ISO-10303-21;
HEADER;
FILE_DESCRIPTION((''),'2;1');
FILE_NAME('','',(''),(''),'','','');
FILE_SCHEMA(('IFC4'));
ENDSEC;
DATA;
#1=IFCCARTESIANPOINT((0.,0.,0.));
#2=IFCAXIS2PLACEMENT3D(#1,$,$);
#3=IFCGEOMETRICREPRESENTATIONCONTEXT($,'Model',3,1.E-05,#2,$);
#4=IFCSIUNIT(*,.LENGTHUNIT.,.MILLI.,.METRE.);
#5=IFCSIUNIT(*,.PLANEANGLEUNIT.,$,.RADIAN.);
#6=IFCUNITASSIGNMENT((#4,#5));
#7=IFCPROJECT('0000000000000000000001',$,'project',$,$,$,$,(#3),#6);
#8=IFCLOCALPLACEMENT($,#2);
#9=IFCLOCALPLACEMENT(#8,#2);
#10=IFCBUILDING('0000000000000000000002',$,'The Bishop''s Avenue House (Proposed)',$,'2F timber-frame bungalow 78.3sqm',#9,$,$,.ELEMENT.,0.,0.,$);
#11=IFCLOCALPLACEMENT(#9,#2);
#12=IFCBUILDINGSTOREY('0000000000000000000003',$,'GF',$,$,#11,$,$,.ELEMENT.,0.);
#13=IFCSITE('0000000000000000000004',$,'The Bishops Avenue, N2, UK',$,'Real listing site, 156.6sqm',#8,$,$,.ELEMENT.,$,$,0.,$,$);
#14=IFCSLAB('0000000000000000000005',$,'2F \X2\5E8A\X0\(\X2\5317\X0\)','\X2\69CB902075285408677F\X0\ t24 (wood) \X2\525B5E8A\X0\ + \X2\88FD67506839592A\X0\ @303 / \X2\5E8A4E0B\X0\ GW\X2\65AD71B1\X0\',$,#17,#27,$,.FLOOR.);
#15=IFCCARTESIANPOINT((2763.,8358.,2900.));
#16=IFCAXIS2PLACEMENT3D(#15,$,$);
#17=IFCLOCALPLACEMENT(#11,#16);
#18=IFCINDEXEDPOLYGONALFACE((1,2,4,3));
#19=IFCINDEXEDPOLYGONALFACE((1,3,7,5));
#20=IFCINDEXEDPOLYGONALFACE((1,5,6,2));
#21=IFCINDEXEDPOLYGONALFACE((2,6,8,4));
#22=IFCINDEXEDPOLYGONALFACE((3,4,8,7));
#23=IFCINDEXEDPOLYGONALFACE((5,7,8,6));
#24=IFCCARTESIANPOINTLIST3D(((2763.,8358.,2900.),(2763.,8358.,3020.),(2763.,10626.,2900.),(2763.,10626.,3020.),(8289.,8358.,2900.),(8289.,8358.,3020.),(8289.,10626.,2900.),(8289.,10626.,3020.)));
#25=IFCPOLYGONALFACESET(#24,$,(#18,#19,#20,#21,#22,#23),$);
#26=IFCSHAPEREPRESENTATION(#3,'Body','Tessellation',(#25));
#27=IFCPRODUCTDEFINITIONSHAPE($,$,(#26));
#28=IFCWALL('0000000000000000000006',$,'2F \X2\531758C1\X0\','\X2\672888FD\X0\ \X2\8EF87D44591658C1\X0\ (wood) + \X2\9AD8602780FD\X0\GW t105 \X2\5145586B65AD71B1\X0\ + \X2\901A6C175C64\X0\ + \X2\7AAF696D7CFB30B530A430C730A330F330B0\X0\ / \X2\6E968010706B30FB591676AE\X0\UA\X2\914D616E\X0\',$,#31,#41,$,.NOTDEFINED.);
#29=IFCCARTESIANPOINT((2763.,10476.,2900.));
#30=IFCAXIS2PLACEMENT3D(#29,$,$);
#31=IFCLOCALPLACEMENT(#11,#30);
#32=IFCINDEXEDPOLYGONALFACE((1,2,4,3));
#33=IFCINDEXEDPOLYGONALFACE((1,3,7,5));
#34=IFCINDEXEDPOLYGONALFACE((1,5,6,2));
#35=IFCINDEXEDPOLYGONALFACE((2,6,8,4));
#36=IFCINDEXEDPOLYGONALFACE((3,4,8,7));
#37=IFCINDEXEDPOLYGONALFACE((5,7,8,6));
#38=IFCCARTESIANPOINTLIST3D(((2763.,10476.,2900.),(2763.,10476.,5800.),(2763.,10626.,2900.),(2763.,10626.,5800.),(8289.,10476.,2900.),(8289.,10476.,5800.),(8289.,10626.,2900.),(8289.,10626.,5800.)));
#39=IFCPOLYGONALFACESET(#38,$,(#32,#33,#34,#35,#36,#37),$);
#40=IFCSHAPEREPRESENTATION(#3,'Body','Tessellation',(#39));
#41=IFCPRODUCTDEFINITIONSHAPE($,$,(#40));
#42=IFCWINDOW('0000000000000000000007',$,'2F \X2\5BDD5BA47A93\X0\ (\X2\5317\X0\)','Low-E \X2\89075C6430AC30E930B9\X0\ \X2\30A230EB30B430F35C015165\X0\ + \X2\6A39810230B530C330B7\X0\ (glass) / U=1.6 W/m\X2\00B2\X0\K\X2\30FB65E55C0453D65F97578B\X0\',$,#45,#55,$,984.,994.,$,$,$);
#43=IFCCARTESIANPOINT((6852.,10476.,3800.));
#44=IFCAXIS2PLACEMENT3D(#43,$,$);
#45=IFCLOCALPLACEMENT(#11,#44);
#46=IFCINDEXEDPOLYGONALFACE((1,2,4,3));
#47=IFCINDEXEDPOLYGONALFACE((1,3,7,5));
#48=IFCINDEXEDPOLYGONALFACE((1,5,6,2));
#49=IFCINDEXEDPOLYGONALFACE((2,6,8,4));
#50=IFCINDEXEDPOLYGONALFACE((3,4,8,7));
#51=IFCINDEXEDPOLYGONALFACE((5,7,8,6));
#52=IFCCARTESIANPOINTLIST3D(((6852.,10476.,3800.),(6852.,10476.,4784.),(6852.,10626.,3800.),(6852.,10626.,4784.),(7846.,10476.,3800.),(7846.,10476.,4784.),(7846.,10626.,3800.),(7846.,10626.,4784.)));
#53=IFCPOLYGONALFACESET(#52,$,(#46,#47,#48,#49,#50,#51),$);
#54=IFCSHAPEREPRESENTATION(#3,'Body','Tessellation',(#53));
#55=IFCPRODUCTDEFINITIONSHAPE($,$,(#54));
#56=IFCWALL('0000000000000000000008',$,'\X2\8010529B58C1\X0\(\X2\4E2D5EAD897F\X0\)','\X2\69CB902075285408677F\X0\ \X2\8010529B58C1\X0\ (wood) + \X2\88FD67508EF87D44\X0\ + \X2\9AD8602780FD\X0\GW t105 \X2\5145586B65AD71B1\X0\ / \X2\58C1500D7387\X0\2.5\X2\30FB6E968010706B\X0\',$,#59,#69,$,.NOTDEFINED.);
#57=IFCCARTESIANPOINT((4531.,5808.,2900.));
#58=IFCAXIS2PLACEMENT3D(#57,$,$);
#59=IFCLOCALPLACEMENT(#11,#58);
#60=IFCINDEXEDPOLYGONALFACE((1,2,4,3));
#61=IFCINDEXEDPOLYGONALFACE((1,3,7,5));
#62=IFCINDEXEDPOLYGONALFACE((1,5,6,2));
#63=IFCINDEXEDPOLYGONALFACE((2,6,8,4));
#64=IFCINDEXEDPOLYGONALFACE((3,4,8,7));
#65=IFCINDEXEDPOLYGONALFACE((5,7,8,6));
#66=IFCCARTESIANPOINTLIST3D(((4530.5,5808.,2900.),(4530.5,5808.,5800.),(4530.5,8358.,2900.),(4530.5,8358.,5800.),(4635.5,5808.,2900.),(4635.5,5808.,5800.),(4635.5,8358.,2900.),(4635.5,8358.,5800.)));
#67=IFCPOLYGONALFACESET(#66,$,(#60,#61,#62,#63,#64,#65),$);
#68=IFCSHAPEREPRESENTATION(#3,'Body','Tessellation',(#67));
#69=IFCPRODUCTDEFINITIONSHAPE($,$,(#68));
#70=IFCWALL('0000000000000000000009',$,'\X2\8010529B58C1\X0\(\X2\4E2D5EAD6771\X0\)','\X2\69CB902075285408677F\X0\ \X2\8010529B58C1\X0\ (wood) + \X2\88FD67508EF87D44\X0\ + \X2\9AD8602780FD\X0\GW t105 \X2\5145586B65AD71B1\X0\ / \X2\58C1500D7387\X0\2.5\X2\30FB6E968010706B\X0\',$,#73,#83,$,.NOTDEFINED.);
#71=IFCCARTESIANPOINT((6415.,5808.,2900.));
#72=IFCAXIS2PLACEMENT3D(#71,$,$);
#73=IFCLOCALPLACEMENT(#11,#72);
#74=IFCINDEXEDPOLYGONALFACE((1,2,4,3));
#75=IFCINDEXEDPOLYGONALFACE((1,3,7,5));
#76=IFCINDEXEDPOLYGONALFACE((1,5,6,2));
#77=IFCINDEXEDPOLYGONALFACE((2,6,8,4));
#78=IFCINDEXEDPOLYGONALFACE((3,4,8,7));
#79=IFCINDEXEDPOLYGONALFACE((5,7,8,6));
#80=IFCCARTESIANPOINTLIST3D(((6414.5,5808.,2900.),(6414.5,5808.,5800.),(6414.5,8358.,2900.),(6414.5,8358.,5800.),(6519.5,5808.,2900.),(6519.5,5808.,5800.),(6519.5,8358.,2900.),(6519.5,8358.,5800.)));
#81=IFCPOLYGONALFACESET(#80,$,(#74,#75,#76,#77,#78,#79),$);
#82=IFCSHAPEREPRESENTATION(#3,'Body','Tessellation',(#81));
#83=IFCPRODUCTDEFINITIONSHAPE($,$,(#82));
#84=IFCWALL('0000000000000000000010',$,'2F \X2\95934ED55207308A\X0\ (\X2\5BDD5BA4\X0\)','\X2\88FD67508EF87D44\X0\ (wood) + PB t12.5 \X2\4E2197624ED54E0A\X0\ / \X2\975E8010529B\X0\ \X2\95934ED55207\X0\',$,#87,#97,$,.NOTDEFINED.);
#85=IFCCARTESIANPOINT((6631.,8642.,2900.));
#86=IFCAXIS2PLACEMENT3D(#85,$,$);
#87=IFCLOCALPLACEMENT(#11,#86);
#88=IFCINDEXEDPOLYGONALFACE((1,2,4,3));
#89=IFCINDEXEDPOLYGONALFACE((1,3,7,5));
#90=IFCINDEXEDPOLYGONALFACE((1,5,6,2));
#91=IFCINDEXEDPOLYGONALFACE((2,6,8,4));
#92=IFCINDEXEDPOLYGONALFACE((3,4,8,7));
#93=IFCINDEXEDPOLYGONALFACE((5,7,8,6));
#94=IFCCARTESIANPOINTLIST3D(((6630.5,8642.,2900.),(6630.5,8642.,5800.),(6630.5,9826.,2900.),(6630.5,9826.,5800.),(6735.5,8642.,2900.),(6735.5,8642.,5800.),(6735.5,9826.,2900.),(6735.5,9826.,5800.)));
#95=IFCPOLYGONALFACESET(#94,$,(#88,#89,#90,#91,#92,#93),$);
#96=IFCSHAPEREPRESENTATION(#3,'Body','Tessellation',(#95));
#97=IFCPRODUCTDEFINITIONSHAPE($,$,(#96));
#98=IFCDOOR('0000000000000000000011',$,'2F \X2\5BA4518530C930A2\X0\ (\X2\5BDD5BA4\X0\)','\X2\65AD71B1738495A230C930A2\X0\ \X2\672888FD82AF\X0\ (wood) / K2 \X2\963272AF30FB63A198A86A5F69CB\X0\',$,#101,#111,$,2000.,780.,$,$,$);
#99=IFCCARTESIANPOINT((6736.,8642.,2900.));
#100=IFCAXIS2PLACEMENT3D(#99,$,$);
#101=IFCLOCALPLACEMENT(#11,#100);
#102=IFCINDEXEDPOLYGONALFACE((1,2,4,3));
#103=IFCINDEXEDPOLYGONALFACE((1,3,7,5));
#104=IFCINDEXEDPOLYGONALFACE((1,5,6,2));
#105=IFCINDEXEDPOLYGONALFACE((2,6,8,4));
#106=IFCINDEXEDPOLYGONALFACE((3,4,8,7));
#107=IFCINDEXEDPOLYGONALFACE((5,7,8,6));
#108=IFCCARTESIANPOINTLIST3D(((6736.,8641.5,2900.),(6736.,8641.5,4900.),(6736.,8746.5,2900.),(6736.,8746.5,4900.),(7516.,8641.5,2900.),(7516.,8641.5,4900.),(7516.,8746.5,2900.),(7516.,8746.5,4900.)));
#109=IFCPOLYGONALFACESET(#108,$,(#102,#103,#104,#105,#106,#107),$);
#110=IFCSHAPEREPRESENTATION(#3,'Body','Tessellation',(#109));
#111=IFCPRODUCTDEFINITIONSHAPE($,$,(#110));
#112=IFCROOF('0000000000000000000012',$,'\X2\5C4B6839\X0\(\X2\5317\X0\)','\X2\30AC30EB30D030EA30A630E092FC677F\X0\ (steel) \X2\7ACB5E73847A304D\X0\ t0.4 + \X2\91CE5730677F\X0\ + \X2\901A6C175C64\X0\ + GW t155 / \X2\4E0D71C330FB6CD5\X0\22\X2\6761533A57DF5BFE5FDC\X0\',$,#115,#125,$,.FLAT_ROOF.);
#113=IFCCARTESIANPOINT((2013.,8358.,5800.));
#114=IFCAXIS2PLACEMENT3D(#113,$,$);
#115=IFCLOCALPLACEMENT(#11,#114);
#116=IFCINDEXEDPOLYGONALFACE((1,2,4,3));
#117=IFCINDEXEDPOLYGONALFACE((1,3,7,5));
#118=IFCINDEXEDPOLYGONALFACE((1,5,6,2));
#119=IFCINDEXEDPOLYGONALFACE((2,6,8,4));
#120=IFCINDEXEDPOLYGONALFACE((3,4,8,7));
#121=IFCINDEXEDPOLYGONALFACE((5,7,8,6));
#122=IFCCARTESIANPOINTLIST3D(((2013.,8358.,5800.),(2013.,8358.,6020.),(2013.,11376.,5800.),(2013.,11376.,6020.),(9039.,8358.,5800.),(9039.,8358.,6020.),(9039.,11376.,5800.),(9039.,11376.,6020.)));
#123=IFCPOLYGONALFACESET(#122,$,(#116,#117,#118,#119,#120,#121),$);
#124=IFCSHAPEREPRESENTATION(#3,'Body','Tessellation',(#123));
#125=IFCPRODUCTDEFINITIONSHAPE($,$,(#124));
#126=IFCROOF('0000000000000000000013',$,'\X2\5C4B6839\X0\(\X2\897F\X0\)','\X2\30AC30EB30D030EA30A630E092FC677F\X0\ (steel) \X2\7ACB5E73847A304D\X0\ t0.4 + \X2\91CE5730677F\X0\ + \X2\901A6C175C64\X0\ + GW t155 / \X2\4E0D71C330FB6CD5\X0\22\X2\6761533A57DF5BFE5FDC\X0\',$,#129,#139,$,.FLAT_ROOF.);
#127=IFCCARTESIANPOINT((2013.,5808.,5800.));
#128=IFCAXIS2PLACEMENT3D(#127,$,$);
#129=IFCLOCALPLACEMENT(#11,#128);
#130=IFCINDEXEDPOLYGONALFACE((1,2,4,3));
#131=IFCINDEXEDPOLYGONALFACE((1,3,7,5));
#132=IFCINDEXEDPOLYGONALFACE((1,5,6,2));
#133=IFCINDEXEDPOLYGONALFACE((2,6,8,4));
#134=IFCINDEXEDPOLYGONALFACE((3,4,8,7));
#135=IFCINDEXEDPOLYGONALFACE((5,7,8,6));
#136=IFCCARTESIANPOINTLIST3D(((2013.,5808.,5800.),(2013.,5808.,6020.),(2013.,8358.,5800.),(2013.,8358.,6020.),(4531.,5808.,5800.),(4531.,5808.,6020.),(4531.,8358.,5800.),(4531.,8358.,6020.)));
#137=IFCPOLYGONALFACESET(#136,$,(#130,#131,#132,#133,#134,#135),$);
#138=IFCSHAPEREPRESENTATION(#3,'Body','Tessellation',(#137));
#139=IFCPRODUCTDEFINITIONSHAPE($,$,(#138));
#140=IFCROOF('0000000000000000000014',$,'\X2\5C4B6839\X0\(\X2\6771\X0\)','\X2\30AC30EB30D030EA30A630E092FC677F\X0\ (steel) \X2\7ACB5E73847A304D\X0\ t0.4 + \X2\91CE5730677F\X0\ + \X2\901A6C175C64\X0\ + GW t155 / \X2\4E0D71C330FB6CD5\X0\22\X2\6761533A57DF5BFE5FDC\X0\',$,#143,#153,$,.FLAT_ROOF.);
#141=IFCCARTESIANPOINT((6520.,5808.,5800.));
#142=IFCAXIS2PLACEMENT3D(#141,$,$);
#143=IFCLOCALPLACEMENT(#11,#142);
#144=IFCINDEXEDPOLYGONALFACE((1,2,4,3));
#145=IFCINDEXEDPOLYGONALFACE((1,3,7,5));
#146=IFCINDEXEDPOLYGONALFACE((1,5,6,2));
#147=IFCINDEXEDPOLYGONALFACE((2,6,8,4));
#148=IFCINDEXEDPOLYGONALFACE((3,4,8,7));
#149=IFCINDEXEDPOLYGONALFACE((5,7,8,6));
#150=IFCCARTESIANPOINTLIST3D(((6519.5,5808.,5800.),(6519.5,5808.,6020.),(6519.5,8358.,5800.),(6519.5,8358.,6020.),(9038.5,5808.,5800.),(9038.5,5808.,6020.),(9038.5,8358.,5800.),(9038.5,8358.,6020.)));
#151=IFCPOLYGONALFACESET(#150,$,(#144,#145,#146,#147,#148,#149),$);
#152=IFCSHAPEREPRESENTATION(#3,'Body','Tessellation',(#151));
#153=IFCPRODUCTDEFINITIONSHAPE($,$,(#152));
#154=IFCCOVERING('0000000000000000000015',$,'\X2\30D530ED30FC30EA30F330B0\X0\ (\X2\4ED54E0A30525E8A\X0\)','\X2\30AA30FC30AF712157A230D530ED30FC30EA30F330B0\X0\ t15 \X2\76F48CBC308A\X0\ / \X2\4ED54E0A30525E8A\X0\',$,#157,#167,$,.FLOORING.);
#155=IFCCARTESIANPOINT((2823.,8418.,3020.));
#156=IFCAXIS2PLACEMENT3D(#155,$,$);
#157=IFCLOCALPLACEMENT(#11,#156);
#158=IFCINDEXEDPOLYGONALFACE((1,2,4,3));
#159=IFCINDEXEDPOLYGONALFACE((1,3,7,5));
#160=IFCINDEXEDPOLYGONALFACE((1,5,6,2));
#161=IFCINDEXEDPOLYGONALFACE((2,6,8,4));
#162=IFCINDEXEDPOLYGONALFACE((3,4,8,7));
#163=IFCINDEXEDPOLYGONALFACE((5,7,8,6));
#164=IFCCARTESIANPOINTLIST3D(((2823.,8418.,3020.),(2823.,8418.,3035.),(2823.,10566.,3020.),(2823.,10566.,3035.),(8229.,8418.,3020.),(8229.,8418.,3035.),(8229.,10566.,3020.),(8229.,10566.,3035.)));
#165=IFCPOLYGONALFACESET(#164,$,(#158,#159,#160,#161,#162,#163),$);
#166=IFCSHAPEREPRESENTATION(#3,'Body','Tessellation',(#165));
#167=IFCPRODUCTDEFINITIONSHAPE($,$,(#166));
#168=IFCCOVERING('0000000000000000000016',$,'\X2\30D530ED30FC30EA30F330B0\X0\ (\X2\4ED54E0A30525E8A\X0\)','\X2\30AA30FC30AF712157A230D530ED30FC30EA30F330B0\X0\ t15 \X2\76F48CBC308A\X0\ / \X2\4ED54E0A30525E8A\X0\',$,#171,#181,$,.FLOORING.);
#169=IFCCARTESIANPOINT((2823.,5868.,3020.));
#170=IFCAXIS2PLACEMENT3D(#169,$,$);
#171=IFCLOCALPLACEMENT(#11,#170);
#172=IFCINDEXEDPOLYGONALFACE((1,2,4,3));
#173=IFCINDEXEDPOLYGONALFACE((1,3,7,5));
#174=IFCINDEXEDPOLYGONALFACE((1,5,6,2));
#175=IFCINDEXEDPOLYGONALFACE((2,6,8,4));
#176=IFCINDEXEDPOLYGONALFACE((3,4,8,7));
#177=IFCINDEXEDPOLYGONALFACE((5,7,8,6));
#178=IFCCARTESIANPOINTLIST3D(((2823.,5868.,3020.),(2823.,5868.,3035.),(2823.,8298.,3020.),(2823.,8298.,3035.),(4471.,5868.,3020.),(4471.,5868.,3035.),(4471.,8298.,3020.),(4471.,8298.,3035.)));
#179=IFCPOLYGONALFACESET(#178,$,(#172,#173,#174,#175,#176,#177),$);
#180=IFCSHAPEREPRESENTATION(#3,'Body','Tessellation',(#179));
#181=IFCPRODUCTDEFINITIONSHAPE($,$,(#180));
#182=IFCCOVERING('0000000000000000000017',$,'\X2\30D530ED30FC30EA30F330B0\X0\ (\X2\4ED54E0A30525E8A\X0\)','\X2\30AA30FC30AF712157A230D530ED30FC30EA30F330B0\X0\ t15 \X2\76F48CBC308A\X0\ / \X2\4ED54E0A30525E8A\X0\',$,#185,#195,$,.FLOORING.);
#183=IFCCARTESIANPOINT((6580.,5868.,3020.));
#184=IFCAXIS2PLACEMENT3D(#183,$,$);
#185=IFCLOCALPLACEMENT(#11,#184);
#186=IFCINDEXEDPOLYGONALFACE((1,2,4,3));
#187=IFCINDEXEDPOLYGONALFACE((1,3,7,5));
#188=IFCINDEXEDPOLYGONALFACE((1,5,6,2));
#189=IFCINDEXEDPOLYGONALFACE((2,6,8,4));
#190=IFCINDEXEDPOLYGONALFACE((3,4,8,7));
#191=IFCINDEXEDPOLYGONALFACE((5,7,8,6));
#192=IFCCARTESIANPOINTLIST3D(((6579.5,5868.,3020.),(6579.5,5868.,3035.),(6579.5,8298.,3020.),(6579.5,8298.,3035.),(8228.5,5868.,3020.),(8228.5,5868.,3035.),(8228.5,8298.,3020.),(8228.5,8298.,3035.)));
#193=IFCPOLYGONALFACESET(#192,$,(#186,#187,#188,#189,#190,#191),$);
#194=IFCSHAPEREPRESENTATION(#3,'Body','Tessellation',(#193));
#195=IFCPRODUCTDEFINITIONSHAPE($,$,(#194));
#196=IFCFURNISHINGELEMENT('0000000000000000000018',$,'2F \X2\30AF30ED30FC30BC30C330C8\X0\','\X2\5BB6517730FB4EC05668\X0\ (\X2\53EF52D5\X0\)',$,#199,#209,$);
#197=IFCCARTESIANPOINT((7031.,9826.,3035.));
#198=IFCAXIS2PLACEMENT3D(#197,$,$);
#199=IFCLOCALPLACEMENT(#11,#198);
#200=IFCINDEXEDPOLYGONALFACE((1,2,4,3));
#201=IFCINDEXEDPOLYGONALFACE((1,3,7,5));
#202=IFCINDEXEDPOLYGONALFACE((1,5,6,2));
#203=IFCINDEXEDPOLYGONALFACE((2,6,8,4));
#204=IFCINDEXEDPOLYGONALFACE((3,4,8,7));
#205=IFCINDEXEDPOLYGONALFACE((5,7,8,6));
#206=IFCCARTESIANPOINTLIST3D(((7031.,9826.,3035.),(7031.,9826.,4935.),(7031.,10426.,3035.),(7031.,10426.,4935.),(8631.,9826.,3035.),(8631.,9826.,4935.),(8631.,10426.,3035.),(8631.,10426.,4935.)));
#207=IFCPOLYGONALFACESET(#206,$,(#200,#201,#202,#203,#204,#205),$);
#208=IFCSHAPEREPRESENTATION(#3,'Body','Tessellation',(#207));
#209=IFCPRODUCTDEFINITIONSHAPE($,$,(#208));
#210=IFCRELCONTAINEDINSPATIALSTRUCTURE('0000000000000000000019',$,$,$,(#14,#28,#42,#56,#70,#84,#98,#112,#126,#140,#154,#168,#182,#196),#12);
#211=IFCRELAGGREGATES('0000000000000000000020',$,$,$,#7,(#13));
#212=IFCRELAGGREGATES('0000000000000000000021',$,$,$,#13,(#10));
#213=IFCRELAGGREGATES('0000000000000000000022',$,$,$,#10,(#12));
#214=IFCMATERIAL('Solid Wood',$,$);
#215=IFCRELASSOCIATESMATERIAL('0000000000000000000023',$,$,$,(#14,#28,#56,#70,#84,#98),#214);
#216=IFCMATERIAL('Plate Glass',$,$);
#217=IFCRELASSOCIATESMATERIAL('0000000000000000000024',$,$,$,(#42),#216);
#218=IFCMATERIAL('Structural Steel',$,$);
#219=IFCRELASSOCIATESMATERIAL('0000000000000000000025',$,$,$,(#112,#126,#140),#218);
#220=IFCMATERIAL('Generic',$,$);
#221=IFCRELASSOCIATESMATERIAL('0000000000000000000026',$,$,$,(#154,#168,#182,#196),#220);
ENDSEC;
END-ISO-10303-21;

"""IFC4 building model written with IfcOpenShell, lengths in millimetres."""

from ifc_helpers import new_model, si_unit, frame, frame_2d, origin, place, context, project, spatial, rectangle, extrude, material, element, fill, save


model = new_model("IFC4")

# Units and contexts
model_context = context("Model", 3, precision=1e-05, world=origin())
ifc_project = project(units=[si_unit("LENGTHUNIT", "METRE", prefix="MILLI"), si_unit("PLANEANGLEUNIT", "RADIAN")], contexts=[model_context])

# Site, building, storey
site_placement = place(None, origin())
site = spatial("IfcSite", under=ifc_project, at=site_placement, Name="The Bishops Avenue, N2, UK", ObjectType="Real listing site, 156.6sqm", CompositionType="ELEMENT", RefElevation=0.0)
building_placement = place(site_placement, origin())
building = spatial("IfcBuilding", under=site, at=building_placement, Name="The Bishop's Avenue House (Proposed)", ObjectType="2F timber-frame bungalow 78.3sqm", CompositionType="ELEMENT", ElevationOfRefHeight=0.0, ElevationOfTerrain=0.0)
storey_placement = place(building_placement, origin())
storey = spatial("IfcBuildingStorey", under=building, at=storey_placement, Name="GF", CompositionType="ELEMENT", Elevation=0.0)

# Slab
ifc_material_1 = material(Name="Solid Wood")
slab_placement = place(storey_placement, frame((2763.0, 8358.0, 2900.0)))
element("IfcSlab", 1, at=slab_placement, inside=storey, material=ifc_material_1, Name="2F 床(北)", Description="構造用合板 t24 (wood) 剛床 + 製材根太 @303 / 床下 GW断熱", PredefinedType="FLOOR", context=model_context, shape_type="SweptSolid", body=[
    extrude(rectangle(XDim=5526.0, YDim=2268.0, at=frame_2d((2763.0, 1134.0))), frame((2763.0, 8358.0, 2900.0)), (0.0, 0.0, 1.0), 120.0),
])

# Wall, opening, window
wall_1_placement = place(storey_placement, frame((2763.0, 10476.0, 2900.0)))
wall_1 = element("IfcWall", 2, at=wall_1_placement, inside=storey, material=ifc_material_1, Name="2F 北壁", Description="木製 軸組外壁 (wood) + 高性能GW t105 充填断熱 + 通気層 + 窯業系サイディング / 準耐火・外皮UA配慮", PredefinedType="NOTDEFINED", context=model_context, shape_type="SweptSolid", body=[
    extrude(rectangle(XDim=5526.0, YDim=150.0, at=frame_2d((2763.0, 75.0))), frame((2763.0, 10476.0, 2900.0)), (0.0, 0.0, 1.0), 2900.0),
])
opening_1_placement = place(storey_placement, frame((6852.0, 10476.0, 3800.0)))
opening_1 = element("IfcOpeningElement", 3, at=opening_1_placement, cuts=wall_1, PredefinedType="NOTDEFINED", context=model_context, shape_type="SweptSolid", body=[
    extrude(rectangle(XDim=994.0, YDim=150.0, at=frame_2d((497.0, 75.0))), frame((6852.0, 10476.0, 3800.0)), (0.0, 0.0, 1.0), 984.0),
])
ifc_material_2 = material(Name="Plate Glass")
window_1_placement = place(storey_placement, frame((6852.0, 10476.0, 3800.0)))
window_1 = element("IfcWindow", 4, at=window_1_placement, inside=storey, material=ifc_material_2, Name="2F 寝室窓 (北)", Description="Low-E 複層ガラス アルゴン封入 + 樹脂サッシ (glass) / U=1.6 W/m²K・日射取得型", OverallHeight=984.0, OverallWidth=994.0, context=model_context, shape_type="SweptSolid", body=[
    extrude(rectangle(XDim=994.0, YDim=150.0, at=frame_2d((497.0, 75.0))), frame((6852.0, 10476.0, 3800.0)), (0.0, 0.0, 1.0), 984.0),
])
fill(opening_1, window_1)

# Walls
wall_2_placement = place(storey_placement, frame((4531.0, 5808.0, 2900.0)))
element("IfcWall", 5, at=wall_2_placement, inside=storey, material=ifc_material_1, Name="耐力壁(中庭西)", Description="構造用合板 耐力壁 (wood) + 製材軸組 + 高性能GW t105 充填断熱 / 壁倍率2.5・準耐火", PredefinedType="NOTDEFINED", context=model_context, shape_type="SweptSolid", body=[
    extrude(rectangle(XDim=105.0, YDim=2550.0, at=frame_2d((52.0, 1275.0))), frame((4531.0, 5808.0, 2900.0)), (0.0, 0.0, 1.0), 2900.0),
])
wall_3_placement = place(storey_placement, frame((6415.0, 5808.0, 2900.0)))
element("IfcWall", 6, at=wall_3_placement, inside=storey, material=ifc_material_1, Name="耐力壁(中庭東)", Description="構造用合板 耐力壁 (wood) + 製材軸組 + 高性能GW t105 充填断熱 / 壁倍率2.5・準耐火", PredefinedType="NOTDEFINED", context=model_context, shape_type="SweptSolid", body=[
    extrude(rectangle(XDim=105.0, YDim=2550.0, at=frame_2d((52.0, 1275.0))), frame((6415.0, 5808.0, 2900.0)), (0.0, 0.0, 1.0), 2900.0),
])
wall_4_placement = place(storey_placement, frame((6631.0, 8642.0, 2900.0)))
element("IfcWall", 7, at=wall_4_placement, inside=storey, material=ifc_material_1, Name="2F 間仕切り (寝室)", Description="製材軸組 (wood) + PB t12.5 両面仕上 / 非耐力 間仕切", PredefinedType="NOTDEFINED", context=model_context, shape_type="SweptSolid", body=[
    extrude(rectangle(XDim=105.0, YDim=1184.0, at=frame_2d((52.0, 592.0))), frame((6631.0, 8642.0, 2900.0)), (0.0, 0.0, 1.0), 2900.0),
])

# Door
door_placement = place(storey_placement, frame((6736.0, 8642.0, 2900.0)))
element("IfcDoor", 8, at=door_placement, inside=storey, material=ifc_material_1, Name="2F 室内ドア (寝室)", Description="断熱玄関ドア 木製芯 (wood) / K2 防犯・採風機構", OverallHeight=2000.0, OverallWidth=780.0, context=model_context, shape_type="SweptSolid", body=[
    extrude(rectangle(XDim=780.0, YDim=105.0, at=frame_2d((390.0, 52.0))), frame((6736.0, 8642.0, 2900.0)), (0.0, 0.0, 1.0), 2000.0),
])

# Roofs
ifc_material_3 = material(Name="Structural Steel")
for number, where, name in (
    (9, (2013.0, 8358.0, 5800.0), "屋根(北)"),
):
    element("IfcRoof", number, at=place(storey_placement, frame(where)), inside=storey, material=ifc_material_3, Name=name, Description="ガルバリウム鋼板 (steel) 立平葺き t0.4 + 野地板 + 通気層 + GW t155 / 不燃・法22条区域対応", PredefinedType="FLAT_ROOF", context=model_context, shape_type="SweptSolid", body=[
        extrude(rectangle(XDim=7026.0, YDim=3018.0, at=frame_2d((3513.0, 1509.0))), frame((2013.0, 8358.0, 5800.0)), (0.0, 0.0, 1.0), 220.0),
    ])
roof_1_placement = place(storey_placement, frame((2013.0, 5808.0, 5800.0)))
element("IfcRoof", 10, at=roof_1_placement, inside=storey, material=ifc_material_3, Name="屋根(西)", Description="ガルバリウム鋼板 (steel) 立平葺き t0.4 + 野地板 + 通気層 + GW t155 / 不燃・法22条区域対応", PredefinedType="FLAT_ROOF", context=model_context, shape_type="SweptSolid", body=[
    extrude(rectangle(XDim=2518.0, YDim=2550.0, at=frame_2d((1259.0, 1275.0))), frame((2013.0, 5808.0, 5800.0)), (0.0, 0.0, 1.0), 220.0),
])
roof_2_placement = place(storey_placement, frame((6520.0, 5808.0, 5800.0)))
element("IfcRoof", 11, at=roof_2_placement, inside=storey, material=ifc_material_3, Name="屋根(東)", Description="ガルバリウム鋼板 (steel) 立平葺き t0.4 + 野地板 + 通気層 + GW t155 / 不燃・法22条区域対応", PredefinedType="FLAT_ROOF", context=model_context, shape_type="SweptSolid", body=[
    extrude(rectangle(XDim=2519.0, YDim=2550.0, at=frame_2d((1259.0, 1275.0))), frame((6520.0, 5808.0, 5800.0)), (0.0, 0.0, 1.0), 220.0),
])

# Coverings
ifc_material_4 = material(Name="Generic")
covering_1_placement = place(storey_placement, frame((2823.0, 8418.0, 3020.0)))
element("IfcCovering", 12, at=covering_1_placement, inside=storey, material=ifc_material_4, Name="フローリング (仕上げ床)", Description="オーク無垢フローリング t15 直貼り / 仕上げ床", PredefinedType="FLOORING", context=model_context, shape_type="SweptSolid", body=[
    extrude(rectangle(XDim=5406.0, YDim=2148.0, at=frame_2d((2703.0, 1074.0))), frame((2823.0, 8418.0, 3020.0)), (0.0, 0.0, 1.0), 15.0),
])
covering_2_placement = place(storey_placement, frame((2823.0, 5868.0, 3020.0)))
element("IfcCovering", 13, at=covering_2_placement, inside=storey, material=ifc_material_4, Name="フローリング (仕上げ床)", Description="オーク無垢フローリング t15 直貼り / 仕上げ床", PredefinedType="FLOORING", context=model_context, shape_type="SweptSolid", body=[
    extrude(rectangle(XDim=1648.0, YDim=2430.0, at=frame_2d((824.0, 1215.0))), frame((2823.0, 5868.0, 3020.0)), (0.0, 0.0, 1.0), 15.0),
])
covering_3_placement = place(storey_placement, frame((6580.0, 5868.0, 3020.0)))
element("IfcCovering", 14, at=covering_3_placement, inside=storey, material=ifc_material_4, Name="フローリング (仕上げ床)", Description="オーク無垢フローリング t15 直貼り / 仕上げ床", PredefinedType="FLOORING", context=model_context, shape_type="SweptSolid", body=[
    extrude(rectangle(XDim=1649.0, YDim=2430.0, at=frame_2d((824.0, 1215.0))), frame((6580.0, 5868.0, 3020.0)), (0.0, 0.0, 1.0), 15.0),
])

# Furnishing element
furnishing_1_placement = place(storey_placement, frame((7031.0, 9826.0, 3035.0)))
element("IfcFurnishingElement", 15, at=furnishing_1_placement, inside=storey, material=ifc_material_4, Name="2F クローゼット", Description="家具・什器 (可動)", context=model_context, shape_type="SweptSolid", body=[
    extrude(rectangle(XDim=1600.0, YDim=600.0, at=frame_2d((800.0, 300.0))), frame((7031.0, 9826.0, 3035.0)), (0.0, 0.0, 1.0), 1900.0),
])

save(model, "model.ifc")
